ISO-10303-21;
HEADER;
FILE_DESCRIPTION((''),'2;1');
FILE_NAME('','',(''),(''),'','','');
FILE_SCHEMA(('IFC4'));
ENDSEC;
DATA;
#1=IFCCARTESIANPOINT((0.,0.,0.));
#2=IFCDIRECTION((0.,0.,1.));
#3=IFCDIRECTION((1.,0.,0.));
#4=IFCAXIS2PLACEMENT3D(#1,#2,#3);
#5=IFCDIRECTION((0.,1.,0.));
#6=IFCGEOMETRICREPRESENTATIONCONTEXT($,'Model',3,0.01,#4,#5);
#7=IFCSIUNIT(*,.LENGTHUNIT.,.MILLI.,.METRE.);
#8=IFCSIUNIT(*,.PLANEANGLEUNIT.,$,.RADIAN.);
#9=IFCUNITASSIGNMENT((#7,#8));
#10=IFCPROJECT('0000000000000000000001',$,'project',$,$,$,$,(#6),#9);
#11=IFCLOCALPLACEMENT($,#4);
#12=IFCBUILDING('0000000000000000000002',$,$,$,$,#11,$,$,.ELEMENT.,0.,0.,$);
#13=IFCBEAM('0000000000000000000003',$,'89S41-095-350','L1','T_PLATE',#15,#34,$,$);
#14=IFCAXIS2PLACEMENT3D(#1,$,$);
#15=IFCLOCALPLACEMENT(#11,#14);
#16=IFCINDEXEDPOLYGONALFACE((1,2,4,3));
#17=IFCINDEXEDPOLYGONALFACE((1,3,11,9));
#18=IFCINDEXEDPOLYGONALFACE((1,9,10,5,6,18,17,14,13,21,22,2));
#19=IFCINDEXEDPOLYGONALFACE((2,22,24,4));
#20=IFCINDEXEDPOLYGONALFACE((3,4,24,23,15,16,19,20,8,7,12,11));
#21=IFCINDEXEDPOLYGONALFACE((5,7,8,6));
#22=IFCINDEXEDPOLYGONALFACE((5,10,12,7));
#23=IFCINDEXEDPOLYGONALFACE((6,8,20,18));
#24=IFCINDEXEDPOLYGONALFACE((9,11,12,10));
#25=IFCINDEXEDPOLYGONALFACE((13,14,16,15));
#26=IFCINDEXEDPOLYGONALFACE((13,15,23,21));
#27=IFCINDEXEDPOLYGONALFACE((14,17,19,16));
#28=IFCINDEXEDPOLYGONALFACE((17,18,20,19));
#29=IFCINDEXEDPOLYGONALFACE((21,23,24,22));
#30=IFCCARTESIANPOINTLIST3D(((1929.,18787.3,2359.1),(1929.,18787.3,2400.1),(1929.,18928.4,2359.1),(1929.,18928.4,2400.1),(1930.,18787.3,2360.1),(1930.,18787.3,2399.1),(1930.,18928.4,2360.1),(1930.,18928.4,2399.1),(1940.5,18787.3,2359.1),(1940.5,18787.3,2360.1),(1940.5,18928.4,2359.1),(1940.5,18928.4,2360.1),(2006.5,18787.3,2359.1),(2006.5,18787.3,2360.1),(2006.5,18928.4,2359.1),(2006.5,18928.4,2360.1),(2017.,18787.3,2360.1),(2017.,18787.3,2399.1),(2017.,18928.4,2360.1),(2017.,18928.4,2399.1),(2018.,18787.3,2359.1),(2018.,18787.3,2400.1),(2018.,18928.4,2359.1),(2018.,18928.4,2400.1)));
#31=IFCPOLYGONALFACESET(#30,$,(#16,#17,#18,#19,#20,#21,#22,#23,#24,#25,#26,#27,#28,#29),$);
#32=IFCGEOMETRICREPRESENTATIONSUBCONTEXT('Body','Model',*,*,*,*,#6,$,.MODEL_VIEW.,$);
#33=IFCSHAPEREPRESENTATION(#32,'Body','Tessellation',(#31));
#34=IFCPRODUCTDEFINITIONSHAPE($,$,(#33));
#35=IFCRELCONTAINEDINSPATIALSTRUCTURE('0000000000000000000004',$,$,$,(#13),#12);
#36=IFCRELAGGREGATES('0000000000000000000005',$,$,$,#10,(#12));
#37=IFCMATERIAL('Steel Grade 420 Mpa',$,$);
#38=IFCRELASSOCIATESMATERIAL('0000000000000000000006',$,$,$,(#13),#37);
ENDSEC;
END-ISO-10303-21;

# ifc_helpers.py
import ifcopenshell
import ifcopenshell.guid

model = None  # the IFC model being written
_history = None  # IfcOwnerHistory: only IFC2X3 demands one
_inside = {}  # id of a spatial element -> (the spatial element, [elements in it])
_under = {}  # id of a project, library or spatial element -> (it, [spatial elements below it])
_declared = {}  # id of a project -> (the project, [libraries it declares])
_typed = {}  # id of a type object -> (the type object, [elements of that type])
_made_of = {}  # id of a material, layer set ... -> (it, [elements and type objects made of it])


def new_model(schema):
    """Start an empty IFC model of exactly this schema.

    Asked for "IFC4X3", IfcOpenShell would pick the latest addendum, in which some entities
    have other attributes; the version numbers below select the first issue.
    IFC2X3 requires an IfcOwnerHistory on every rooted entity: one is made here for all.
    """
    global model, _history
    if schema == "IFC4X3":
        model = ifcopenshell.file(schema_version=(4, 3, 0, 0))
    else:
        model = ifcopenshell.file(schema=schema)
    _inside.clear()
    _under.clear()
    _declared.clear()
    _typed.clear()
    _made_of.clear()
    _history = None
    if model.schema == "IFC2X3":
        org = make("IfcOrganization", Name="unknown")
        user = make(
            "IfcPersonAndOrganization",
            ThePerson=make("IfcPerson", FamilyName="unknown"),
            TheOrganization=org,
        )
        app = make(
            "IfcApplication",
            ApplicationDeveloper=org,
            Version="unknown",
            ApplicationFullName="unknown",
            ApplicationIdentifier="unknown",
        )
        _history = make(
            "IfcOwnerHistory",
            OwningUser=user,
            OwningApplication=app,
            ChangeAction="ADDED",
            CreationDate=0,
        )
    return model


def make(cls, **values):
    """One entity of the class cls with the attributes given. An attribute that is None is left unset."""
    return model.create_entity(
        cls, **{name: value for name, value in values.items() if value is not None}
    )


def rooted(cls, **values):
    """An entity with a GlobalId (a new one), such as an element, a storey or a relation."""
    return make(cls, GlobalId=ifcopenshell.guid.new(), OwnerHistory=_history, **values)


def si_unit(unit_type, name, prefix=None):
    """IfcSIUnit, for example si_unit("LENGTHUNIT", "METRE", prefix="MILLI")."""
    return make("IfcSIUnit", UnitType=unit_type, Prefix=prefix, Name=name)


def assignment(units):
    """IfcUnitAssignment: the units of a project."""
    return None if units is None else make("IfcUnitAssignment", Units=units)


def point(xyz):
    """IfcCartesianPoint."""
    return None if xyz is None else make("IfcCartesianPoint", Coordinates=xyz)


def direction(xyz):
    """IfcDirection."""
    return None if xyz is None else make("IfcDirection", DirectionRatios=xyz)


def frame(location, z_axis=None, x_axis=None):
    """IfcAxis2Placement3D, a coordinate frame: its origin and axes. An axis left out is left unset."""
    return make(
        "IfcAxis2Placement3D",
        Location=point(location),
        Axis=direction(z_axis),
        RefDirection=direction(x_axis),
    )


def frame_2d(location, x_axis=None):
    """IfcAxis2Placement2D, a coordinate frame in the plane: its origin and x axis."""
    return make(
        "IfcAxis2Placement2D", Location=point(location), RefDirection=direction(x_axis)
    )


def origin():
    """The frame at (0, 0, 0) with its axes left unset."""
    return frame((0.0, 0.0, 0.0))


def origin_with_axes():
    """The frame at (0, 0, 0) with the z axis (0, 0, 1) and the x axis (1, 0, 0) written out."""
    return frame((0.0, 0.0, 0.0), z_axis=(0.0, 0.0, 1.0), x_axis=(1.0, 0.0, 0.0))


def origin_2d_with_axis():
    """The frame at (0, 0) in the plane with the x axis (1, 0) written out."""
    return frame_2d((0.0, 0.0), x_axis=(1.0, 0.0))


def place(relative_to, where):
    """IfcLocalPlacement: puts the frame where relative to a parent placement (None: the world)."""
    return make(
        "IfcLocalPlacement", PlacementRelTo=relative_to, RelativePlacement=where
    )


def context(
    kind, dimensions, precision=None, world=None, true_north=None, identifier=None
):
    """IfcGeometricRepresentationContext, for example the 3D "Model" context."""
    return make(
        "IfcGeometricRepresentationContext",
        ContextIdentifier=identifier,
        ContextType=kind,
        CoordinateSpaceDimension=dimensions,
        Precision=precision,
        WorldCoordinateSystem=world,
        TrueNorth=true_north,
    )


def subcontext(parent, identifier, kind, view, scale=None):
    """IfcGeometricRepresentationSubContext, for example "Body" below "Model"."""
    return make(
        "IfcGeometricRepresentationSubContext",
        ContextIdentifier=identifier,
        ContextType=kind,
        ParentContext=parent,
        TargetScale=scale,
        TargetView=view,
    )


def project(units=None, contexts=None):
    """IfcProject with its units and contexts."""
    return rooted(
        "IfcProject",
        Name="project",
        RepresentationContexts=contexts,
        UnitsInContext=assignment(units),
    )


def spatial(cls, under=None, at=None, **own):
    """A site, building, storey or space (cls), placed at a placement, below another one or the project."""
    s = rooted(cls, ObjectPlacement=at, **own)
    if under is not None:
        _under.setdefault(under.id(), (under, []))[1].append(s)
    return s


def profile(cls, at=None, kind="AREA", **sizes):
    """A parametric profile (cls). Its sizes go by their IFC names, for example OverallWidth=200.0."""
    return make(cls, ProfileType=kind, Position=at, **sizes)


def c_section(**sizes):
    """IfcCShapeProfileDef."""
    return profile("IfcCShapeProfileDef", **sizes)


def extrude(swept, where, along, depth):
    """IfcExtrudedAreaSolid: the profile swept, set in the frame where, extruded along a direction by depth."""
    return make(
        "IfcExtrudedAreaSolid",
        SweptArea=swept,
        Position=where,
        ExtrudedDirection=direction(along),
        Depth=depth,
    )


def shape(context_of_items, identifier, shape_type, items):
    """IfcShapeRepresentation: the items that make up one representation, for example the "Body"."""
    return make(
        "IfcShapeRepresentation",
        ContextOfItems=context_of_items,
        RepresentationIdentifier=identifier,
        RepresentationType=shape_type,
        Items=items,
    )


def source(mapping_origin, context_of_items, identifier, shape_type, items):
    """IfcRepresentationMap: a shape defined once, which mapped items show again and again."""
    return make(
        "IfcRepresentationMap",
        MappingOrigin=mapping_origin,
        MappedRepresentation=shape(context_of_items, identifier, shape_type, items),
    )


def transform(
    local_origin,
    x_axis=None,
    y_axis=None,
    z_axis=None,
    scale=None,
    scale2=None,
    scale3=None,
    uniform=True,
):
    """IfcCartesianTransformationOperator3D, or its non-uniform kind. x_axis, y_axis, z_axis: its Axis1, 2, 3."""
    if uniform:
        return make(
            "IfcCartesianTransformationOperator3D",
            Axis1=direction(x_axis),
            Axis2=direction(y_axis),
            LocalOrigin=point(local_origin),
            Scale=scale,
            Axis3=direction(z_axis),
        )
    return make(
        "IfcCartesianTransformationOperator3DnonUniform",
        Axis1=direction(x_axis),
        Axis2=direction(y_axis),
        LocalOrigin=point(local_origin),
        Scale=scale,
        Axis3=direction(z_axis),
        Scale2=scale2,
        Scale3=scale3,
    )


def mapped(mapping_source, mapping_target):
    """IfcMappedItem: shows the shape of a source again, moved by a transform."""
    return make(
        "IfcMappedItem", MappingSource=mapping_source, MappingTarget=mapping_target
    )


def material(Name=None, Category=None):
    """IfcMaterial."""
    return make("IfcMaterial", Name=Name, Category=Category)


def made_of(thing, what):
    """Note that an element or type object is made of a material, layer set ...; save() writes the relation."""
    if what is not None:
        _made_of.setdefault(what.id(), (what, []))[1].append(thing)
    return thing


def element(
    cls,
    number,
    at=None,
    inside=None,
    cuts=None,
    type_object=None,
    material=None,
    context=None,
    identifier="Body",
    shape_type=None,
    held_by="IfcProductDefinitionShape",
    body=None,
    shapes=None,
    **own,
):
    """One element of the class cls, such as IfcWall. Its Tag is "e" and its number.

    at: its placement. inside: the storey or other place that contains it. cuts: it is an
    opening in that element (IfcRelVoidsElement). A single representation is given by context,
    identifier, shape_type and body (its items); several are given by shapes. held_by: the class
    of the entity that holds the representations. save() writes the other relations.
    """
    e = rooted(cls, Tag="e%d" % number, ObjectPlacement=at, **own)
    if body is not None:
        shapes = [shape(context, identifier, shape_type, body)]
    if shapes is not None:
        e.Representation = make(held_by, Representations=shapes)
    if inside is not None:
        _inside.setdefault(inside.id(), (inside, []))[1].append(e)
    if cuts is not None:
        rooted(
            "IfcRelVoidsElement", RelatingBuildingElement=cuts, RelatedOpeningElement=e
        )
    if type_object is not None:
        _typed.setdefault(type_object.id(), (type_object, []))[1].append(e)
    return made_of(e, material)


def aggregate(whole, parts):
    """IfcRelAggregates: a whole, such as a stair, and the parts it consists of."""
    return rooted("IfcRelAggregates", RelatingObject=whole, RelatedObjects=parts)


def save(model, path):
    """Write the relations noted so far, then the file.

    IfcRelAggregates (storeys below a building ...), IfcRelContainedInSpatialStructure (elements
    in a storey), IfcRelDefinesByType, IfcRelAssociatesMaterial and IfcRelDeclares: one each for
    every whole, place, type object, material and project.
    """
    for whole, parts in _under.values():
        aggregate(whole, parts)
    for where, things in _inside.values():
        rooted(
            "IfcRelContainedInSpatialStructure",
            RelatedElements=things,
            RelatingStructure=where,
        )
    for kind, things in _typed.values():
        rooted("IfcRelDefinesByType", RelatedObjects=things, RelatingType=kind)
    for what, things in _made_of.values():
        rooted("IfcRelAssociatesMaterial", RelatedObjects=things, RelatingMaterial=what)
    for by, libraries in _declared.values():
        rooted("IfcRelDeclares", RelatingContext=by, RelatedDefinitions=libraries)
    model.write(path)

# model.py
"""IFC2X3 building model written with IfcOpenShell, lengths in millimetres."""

from ifc_helpers import new_model, si_unit, direction, frame, origin, origin_with_axes, origin_2d_with_axis, place, context, subcontext, project, spatial, c_section, extrude, source, transform, mapped, material, element, save


model = new_model("IFC2X3")

# Units and contexts
model_context = context("Model", 3, precision=0.01, world=origin_with_axes(), true_north=direction((0.0, 1.0, 0.0)))
body_context = subcontext(model_context, "Body", "Model", "MODEL_VIEW")
ifc_project = project(units=[si_unit("LENGTHUNIT", "METRE", prefix="MILLI"), si_unit("PLANEANGLEUNIT", "RADIAN")], contexts=[model_context])

# Building
building_placement = place(None, origin_with_axes())
building = spatial("IfcBuilding", under=ifc_project, at=building_placement, CompositionType="ELEMENT", ElevationOfRefHeight=0.0, ElevationOfTerrain=0.0)

# Shared definitions
ifc_material_1 = material(Name="Steel Grade 420 Mpa")

# Beam
shared_shape_1 = source(origin(), body_context, "Body", "SweptSolid", [
    extrude(c_section(Depth=89.0, Width=41.0, WallThickness=1.0, Girth=11.5, at=origin_2d_with_axis()), origin_with_axes(), (0.0, 0.0, 1.0), 141.0),
])
beam_1_placement = place(None, frame((1973.5, 18928.4, 2379.6), z_axis=(0.0, -1.0, 0.0), x_axis=(0.0, 0.0, -1.0)))
element("IfcBeam", 1, at=beam_1_placement, inside=building, material=ifc_material_1, Name="89S41-095-350", Description="L1", ObjectType="T_PLATE", context=body_context, shape_type="MappedRepresentation", body=[
    mapped(shared_shape_1, transform((0.0, 0.0, 0.0), scale=1.0)),
])

save(model, "model.ifc")
